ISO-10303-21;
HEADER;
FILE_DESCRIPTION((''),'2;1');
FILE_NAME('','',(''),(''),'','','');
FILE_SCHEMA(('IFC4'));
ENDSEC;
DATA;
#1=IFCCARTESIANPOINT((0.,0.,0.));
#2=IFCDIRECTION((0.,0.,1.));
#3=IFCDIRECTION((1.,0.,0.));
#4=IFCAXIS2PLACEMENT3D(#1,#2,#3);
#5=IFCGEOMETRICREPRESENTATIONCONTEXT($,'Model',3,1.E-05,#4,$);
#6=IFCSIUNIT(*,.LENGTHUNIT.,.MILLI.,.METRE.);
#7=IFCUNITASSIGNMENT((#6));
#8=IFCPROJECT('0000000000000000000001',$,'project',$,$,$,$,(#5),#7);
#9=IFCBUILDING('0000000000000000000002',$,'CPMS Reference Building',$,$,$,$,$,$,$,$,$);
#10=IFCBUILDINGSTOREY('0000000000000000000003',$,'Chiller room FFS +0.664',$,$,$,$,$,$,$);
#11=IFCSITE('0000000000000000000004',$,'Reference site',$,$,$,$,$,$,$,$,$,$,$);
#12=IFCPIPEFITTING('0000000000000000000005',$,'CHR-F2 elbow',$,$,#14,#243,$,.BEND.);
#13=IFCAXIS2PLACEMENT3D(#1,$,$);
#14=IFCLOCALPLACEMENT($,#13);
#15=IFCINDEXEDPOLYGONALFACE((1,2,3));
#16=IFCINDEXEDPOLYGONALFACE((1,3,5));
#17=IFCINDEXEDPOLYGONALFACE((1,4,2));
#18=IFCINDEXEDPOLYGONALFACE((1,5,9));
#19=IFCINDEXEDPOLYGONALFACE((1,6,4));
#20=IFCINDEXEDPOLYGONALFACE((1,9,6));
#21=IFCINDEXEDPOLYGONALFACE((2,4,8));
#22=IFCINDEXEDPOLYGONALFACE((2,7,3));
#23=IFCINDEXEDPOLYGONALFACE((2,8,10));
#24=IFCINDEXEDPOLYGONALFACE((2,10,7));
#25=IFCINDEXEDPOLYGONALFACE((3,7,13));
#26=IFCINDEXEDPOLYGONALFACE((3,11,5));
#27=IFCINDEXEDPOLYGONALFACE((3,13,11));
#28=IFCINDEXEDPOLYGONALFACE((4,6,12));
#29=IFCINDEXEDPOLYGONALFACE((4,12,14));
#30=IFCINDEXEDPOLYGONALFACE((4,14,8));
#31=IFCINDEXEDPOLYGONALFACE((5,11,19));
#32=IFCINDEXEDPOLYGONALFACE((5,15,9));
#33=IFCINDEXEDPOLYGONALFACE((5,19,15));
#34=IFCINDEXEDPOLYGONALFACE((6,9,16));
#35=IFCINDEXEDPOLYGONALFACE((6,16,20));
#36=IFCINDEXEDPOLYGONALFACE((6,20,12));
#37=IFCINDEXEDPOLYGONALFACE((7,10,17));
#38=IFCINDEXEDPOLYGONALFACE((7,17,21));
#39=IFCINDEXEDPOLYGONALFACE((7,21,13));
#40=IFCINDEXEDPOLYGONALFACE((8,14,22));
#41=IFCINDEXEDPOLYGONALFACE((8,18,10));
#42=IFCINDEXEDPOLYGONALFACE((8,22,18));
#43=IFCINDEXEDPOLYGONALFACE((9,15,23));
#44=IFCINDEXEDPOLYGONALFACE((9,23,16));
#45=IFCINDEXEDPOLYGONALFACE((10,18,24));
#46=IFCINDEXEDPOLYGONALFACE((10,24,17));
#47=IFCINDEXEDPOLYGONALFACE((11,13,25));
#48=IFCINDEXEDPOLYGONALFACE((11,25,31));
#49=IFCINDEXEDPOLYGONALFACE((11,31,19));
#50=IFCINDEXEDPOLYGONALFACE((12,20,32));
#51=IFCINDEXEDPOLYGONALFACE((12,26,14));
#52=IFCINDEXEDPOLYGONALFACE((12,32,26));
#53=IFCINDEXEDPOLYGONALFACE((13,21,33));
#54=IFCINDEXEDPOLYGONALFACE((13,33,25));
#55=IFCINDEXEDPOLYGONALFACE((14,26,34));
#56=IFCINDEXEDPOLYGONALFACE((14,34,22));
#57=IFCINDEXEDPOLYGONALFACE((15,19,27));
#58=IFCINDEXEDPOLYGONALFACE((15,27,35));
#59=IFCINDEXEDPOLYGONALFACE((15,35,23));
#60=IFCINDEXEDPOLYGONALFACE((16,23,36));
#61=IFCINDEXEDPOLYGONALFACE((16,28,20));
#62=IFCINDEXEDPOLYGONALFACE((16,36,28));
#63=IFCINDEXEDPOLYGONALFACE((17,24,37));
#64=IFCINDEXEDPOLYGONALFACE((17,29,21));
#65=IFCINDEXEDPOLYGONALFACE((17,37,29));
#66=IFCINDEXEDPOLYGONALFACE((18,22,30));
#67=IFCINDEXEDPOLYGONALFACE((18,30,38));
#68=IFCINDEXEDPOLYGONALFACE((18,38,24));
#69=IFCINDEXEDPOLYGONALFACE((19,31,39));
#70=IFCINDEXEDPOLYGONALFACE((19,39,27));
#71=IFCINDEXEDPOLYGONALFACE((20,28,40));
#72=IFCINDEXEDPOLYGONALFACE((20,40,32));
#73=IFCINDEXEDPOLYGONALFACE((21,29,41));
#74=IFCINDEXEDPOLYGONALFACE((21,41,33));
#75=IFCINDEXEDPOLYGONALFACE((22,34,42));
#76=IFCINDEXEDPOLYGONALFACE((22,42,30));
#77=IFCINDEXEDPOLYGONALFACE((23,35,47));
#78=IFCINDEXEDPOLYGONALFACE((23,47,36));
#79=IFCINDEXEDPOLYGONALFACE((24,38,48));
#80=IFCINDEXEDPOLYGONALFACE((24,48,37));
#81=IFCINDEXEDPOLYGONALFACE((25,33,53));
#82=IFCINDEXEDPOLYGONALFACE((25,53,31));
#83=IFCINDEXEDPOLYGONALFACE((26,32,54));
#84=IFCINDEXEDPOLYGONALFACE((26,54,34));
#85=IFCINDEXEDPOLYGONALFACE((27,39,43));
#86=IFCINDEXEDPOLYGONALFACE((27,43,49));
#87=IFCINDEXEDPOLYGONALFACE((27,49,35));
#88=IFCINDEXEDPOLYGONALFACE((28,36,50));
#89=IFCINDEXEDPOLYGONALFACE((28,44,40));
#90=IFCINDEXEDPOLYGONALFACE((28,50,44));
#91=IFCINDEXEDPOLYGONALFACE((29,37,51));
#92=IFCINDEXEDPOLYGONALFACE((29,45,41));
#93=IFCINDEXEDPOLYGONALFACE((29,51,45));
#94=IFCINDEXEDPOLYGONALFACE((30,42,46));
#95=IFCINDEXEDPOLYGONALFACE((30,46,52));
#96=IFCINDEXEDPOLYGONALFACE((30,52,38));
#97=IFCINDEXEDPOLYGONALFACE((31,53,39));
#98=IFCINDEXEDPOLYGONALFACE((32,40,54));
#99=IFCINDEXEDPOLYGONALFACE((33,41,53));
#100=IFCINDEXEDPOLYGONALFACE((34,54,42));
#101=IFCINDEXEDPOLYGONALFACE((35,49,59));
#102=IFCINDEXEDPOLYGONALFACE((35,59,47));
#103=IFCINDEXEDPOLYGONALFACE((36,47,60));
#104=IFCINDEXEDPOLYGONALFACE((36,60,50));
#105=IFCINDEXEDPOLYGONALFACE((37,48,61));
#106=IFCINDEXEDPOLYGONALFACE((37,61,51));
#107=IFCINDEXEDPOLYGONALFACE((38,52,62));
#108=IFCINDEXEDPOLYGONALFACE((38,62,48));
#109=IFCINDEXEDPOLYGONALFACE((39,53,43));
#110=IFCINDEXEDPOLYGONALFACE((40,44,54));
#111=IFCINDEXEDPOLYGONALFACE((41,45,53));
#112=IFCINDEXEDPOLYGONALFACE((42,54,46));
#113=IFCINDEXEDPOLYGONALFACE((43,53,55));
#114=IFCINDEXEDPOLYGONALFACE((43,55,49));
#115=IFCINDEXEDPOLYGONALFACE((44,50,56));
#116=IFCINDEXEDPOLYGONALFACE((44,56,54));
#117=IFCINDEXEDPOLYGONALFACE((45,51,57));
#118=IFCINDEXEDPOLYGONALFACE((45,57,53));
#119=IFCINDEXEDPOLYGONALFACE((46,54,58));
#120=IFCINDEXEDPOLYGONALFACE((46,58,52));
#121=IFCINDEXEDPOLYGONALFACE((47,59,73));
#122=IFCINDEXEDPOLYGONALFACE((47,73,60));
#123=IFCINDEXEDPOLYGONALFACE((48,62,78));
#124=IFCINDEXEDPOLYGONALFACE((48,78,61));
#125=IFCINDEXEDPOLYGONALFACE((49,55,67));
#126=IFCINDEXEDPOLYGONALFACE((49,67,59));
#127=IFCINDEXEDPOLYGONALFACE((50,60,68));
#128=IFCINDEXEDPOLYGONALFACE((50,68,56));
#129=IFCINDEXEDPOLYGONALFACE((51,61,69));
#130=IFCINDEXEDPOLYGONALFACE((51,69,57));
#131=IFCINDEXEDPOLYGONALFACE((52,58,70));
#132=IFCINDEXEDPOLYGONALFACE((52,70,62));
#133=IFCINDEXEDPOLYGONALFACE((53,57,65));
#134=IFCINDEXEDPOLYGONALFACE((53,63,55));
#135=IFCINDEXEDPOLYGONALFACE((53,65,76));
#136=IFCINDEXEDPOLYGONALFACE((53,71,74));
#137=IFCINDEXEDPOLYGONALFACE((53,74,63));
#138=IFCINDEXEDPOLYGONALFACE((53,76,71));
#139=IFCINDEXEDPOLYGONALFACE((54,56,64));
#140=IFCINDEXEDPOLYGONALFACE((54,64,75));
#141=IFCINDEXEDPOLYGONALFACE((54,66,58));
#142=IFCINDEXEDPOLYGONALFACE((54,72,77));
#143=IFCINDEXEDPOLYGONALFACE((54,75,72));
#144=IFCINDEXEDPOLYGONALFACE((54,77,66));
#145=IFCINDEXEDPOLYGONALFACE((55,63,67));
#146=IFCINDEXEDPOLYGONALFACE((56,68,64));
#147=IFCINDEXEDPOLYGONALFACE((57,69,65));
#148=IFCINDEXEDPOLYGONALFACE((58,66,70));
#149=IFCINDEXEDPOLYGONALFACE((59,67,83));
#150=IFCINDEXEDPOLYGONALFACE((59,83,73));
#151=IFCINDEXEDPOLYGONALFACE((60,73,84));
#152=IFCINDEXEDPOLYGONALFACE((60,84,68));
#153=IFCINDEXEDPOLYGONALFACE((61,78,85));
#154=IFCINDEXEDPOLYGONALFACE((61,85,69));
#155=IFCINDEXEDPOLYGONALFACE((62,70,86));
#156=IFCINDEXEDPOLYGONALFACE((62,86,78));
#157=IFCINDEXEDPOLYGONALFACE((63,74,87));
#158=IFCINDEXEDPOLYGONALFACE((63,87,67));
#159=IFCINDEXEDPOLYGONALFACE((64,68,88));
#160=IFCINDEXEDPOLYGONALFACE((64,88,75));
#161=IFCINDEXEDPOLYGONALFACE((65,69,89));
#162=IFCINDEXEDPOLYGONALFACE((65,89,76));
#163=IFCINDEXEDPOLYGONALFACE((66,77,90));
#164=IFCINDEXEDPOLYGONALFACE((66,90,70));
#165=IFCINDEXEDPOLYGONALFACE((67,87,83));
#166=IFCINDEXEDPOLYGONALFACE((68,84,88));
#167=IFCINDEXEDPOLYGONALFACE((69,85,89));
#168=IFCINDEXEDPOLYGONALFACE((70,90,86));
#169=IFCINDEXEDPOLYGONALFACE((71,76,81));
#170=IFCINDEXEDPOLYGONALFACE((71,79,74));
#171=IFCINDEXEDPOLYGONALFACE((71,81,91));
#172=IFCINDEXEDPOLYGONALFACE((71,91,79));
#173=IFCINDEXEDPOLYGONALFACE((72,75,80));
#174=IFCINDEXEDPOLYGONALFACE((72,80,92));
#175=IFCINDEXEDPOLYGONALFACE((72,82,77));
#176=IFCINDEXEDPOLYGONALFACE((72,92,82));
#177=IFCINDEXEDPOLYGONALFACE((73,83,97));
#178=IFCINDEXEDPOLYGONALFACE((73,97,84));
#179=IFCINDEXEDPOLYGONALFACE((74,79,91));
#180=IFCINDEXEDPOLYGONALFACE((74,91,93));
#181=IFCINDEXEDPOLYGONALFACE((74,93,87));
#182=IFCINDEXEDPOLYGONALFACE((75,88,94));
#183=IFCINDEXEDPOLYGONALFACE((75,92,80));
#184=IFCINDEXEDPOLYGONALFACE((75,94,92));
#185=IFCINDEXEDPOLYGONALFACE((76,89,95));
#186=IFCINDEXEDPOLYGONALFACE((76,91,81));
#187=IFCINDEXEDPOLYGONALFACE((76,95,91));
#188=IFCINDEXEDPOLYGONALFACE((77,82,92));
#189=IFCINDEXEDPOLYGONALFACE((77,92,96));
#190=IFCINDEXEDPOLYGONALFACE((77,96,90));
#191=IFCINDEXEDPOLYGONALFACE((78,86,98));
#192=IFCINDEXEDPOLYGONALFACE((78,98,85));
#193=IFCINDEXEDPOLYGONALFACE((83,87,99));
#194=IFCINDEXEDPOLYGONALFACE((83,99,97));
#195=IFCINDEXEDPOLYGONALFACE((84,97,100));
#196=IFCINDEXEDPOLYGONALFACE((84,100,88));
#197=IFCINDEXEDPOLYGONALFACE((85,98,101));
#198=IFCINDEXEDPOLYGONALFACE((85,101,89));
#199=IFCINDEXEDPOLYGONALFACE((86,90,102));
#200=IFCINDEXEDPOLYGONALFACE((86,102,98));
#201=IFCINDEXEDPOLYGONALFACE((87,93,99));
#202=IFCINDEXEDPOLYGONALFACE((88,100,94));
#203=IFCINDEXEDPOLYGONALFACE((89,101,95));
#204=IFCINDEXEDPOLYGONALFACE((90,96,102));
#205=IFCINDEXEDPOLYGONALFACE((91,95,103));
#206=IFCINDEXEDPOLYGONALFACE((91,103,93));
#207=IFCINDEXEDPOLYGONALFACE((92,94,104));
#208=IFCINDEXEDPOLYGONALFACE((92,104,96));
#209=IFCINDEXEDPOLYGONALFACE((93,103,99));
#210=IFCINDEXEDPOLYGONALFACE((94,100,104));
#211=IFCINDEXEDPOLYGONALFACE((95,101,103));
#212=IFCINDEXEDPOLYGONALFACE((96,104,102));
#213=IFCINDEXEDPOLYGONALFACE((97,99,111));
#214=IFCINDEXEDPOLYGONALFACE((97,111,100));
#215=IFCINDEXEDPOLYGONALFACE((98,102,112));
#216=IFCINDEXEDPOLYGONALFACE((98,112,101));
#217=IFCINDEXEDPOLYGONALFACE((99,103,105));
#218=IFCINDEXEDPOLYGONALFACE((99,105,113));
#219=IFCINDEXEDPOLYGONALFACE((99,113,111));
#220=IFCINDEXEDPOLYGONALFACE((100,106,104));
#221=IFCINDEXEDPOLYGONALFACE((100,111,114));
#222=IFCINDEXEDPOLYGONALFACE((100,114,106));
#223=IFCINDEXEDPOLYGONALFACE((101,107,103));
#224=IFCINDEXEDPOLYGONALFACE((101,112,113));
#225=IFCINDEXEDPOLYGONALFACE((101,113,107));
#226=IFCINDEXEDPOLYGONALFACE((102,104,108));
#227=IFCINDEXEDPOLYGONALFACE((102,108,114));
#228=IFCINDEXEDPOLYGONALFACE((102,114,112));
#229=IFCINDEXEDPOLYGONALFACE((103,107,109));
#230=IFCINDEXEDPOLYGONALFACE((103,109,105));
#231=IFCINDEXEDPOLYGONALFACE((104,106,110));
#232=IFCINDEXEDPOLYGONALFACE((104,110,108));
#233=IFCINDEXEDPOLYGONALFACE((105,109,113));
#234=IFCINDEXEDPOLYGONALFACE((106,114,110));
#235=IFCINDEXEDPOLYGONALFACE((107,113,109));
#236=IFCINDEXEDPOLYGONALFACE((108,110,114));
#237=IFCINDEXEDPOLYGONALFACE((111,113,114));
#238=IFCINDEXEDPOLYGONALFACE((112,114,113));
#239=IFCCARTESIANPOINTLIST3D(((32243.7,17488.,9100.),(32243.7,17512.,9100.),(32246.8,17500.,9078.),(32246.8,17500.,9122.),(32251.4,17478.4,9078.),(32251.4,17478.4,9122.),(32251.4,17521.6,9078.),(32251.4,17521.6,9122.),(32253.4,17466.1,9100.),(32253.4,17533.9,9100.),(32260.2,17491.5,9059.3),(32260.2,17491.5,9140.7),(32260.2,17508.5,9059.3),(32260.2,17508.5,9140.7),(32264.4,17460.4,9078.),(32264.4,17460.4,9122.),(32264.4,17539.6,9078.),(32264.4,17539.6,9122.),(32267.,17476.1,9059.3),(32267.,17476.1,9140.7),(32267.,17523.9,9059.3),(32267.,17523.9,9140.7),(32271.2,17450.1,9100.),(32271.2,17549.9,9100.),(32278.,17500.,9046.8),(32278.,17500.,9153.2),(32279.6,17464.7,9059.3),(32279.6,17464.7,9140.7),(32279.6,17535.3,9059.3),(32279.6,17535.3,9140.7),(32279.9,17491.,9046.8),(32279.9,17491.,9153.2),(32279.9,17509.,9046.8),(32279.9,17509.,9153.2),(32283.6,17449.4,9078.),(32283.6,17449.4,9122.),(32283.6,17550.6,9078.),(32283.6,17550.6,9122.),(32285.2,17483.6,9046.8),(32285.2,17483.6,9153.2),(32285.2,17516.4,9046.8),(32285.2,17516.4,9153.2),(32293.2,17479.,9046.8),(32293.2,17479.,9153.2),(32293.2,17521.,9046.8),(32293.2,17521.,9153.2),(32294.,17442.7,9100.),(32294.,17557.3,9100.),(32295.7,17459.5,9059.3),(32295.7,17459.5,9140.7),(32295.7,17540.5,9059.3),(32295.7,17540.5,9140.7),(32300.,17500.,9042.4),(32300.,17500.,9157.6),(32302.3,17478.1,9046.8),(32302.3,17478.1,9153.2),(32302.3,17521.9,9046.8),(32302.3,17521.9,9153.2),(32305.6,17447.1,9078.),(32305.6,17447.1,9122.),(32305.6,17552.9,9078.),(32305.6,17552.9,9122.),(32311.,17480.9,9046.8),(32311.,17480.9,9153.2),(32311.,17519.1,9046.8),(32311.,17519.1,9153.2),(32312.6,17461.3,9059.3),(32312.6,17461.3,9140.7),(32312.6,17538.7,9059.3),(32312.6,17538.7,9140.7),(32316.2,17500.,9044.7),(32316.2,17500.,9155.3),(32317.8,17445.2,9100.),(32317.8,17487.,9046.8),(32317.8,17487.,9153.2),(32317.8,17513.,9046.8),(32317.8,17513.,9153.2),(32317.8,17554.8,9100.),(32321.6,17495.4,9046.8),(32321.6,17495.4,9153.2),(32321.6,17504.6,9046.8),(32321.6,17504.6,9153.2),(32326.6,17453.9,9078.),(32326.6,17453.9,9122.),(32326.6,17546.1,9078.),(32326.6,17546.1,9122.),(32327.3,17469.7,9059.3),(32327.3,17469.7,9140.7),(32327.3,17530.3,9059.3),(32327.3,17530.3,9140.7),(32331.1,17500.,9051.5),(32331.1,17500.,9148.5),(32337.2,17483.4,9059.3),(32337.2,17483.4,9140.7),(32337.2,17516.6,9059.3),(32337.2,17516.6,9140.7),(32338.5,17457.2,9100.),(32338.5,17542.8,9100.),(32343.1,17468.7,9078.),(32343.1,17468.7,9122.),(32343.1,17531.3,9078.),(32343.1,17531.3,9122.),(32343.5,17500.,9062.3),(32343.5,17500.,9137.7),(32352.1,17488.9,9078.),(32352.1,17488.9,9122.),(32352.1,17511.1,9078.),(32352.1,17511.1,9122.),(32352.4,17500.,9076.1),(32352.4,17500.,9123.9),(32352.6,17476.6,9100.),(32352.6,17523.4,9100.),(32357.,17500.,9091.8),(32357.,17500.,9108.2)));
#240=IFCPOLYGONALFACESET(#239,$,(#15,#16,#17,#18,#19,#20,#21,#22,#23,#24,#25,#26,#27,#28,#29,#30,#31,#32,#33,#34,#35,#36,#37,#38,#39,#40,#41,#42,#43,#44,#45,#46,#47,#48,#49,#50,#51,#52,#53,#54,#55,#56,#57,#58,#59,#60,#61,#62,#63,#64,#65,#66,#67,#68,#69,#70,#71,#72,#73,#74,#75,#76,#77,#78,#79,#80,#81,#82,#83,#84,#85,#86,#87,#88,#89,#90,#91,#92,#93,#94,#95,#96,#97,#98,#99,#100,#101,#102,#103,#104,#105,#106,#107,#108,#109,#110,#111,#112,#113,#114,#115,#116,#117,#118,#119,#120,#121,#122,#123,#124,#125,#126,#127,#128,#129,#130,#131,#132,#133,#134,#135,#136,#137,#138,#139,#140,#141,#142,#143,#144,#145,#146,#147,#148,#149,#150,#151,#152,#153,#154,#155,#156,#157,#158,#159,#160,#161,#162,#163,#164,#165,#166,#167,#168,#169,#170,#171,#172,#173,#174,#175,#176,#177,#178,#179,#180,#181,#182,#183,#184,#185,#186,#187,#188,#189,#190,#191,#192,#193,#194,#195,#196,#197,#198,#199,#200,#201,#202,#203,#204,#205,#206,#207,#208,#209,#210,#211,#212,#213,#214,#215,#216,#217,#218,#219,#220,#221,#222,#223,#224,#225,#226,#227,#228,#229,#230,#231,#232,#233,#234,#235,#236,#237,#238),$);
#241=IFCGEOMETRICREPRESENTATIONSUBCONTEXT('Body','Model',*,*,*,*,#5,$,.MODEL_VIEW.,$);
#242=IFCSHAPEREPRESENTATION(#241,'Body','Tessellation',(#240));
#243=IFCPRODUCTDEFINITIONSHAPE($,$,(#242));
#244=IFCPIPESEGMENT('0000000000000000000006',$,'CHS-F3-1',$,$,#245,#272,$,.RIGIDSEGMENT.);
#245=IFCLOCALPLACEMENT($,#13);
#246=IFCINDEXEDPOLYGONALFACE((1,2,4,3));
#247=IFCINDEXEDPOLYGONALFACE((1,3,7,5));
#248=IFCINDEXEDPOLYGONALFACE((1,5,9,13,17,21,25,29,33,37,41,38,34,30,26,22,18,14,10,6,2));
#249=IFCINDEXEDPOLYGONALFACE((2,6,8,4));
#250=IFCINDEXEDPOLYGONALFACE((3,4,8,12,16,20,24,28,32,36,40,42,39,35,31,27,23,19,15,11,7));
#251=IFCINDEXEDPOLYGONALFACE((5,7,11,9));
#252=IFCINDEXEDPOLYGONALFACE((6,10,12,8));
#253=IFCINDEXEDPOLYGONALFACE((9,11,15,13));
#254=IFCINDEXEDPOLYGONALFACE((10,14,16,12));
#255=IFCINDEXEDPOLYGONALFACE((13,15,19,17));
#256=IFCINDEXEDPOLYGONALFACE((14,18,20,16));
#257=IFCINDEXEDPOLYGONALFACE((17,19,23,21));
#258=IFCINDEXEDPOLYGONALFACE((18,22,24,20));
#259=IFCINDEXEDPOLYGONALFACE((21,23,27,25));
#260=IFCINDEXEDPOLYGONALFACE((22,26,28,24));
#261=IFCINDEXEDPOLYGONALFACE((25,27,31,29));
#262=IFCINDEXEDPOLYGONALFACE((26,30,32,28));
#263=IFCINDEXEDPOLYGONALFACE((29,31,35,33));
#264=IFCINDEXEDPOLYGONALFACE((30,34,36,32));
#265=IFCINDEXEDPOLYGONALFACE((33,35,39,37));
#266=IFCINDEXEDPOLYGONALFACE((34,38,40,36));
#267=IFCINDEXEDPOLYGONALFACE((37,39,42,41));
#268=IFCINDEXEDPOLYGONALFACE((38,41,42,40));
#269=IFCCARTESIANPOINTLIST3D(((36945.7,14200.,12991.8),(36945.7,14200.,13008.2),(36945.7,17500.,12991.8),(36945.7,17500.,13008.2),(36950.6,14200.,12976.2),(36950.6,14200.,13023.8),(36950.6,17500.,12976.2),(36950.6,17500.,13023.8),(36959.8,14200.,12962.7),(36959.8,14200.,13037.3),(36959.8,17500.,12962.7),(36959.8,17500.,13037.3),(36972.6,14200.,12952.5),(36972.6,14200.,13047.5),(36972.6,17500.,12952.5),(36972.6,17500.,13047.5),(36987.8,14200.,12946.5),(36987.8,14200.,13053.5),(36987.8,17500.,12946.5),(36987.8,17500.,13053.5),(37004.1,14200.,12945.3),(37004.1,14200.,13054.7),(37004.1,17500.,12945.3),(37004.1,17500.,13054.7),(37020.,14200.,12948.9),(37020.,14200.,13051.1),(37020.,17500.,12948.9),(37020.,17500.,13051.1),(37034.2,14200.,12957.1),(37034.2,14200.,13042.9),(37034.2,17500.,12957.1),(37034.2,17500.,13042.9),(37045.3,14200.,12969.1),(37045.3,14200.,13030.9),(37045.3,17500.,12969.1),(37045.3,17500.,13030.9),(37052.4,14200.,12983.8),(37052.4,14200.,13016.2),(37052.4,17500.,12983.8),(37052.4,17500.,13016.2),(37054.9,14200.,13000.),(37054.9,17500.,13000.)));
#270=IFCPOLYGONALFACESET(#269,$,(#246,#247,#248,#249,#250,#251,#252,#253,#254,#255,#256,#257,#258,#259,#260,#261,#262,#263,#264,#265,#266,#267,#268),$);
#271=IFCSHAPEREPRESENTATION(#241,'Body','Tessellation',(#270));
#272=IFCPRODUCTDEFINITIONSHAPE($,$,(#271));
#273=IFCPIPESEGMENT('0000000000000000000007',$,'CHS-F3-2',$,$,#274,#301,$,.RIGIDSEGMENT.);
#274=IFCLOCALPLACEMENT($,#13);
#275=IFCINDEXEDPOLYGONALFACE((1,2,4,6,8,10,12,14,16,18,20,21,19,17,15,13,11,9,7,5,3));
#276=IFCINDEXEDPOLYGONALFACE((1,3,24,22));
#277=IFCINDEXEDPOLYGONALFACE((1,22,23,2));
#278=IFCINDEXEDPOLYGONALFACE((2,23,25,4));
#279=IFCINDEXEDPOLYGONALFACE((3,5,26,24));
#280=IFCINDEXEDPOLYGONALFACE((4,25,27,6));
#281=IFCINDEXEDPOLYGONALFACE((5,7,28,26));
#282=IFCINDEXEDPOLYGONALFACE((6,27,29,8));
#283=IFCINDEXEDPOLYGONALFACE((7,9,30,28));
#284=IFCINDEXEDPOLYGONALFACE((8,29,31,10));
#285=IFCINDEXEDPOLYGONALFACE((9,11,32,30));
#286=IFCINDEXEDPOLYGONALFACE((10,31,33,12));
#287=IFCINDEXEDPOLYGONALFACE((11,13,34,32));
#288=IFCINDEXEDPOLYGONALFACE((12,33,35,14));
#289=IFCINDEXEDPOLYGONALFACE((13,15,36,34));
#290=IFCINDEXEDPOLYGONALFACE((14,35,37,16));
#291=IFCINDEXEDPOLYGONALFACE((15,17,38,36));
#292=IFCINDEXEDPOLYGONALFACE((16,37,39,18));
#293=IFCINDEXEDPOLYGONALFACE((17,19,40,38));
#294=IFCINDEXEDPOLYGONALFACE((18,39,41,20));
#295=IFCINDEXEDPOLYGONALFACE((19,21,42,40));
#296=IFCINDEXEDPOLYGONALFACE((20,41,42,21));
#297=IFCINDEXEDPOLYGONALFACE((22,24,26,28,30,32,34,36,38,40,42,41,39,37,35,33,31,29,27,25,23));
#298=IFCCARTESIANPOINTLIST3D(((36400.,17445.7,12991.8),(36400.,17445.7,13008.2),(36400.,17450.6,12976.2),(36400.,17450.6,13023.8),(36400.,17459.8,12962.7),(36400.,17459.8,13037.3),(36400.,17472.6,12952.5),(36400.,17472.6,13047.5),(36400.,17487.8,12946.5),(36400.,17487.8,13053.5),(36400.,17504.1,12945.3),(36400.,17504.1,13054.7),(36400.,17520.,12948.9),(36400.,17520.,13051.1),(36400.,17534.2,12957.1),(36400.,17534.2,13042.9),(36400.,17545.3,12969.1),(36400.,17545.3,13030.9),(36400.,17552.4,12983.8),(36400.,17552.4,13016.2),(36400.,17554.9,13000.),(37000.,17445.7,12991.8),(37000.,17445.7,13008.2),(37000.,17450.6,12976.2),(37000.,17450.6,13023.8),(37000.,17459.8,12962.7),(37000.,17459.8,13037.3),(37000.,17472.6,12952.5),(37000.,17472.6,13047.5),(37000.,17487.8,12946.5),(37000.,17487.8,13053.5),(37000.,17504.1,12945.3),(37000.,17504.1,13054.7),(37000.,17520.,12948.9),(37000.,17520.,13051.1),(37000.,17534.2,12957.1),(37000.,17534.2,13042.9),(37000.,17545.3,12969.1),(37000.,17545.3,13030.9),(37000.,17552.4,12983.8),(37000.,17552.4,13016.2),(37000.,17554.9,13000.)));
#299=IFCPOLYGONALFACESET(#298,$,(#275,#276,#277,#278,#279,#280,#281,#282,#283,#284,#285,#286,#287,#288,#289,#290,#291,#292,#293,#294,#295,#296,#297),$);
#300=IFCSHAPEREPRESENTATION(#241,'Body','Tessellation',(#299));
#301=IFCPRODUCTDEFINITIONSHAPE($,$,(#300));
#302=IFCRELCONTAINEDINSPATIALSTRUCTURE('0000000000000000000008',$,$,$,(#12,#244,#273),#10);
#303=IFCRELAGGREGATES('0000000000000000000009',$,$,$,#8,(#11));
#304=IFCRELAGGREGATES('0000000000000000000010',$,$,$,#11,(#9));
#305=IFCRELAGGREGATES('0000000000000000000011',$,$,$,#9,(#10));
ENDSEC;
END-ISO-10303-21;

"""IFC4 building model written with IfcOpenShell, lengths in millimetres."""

from ifc_helpers import new_model, entity, si_unit, frame, origin_with_axes, origin_2d, place, context, subcontext, project, spatial, circle_curve, outline, extrude, element, save


model = new_model("IFC4")

# Units and contexts
model_context = context("Model", 3, precision=1e-05, world=origin_with_axes())
body_context = subcontext(model_context, "Body", "Model", "MODEL_VIEW")
ifc_project = project(units=[si_unit("LENGTHUNIT", "METRE", prefix="MILLI")], contexts=[model_context])

# Site, building, storey
site = spatial("IfcSite", under=ifc_project, Name="Reference site")
building = spatial("IfcBuilding", under=site, Name="CPMS Reference Building")
storey = spatial("IfcBuildingStorey", under=building, Name="Chiller room FFS +0.664")

# Pipe fitting
pipe_fitting_1_placement = place(None, origin_with_axes())
element("IfcPipeFitting", 1, at=pipe_fitting_1_placement, inside=storey, Name="CHR-F2 elbow", PredefinedType="BEND", context=body_context, shape_type="CSG", body=[
    entity("IfcSphere", entity("IfcAxis2Placement3D", entity("IfcCartesianPoint", [32300.0, 17500.0, 9100.0]), entity("IfcDirection", [0.0, 0.0, 1.0]), entity("IfcDirection", [1.0, 0.0, 0.0])), 57.6),
])

# Pipe segments
pipe_segment_1_placement = place(None, origin_with_axes())
element("IfcPipeSegment", 2, at=pipe_segment_1_placement, inside=storey, Name="CHS-F3-1", PredefinedType="RIGIDSEGMENT", context=body_context, shape_type="SweptSolid", body=[
    extrude(outline(circle_curve(origin_2d(), 54.9)), frame((37000.0, 14200.0, 13000.0), z_axis=(0.0, 1.0, 0.0), x_axis=(1.0, 0.0, 0.0)), (0.0, 0.0, 1.0), 3300.0),
])
pipe_segment_2_placement = place(None, origin_with_axes())
element("IfcPipeSegment", 3, at=pipe_segment_2_placement, inside=storey, Name="CHS-F3-2", PredefinedType="RIGIDSEGMENT", context=body_context, shape_type="SweptSolid", body=[
    extrude(outline(circle_curve(origin_2d(), 54.9)), frame((37000.0, 17500.0, 13000.0), z_axis=(-1.0, 0.0, 0.0), x_axis=(0.0, 1.0, 0.0)), (0.0, 0.0, 1.0), 600.0),
])

save(model, "model.ifc")
